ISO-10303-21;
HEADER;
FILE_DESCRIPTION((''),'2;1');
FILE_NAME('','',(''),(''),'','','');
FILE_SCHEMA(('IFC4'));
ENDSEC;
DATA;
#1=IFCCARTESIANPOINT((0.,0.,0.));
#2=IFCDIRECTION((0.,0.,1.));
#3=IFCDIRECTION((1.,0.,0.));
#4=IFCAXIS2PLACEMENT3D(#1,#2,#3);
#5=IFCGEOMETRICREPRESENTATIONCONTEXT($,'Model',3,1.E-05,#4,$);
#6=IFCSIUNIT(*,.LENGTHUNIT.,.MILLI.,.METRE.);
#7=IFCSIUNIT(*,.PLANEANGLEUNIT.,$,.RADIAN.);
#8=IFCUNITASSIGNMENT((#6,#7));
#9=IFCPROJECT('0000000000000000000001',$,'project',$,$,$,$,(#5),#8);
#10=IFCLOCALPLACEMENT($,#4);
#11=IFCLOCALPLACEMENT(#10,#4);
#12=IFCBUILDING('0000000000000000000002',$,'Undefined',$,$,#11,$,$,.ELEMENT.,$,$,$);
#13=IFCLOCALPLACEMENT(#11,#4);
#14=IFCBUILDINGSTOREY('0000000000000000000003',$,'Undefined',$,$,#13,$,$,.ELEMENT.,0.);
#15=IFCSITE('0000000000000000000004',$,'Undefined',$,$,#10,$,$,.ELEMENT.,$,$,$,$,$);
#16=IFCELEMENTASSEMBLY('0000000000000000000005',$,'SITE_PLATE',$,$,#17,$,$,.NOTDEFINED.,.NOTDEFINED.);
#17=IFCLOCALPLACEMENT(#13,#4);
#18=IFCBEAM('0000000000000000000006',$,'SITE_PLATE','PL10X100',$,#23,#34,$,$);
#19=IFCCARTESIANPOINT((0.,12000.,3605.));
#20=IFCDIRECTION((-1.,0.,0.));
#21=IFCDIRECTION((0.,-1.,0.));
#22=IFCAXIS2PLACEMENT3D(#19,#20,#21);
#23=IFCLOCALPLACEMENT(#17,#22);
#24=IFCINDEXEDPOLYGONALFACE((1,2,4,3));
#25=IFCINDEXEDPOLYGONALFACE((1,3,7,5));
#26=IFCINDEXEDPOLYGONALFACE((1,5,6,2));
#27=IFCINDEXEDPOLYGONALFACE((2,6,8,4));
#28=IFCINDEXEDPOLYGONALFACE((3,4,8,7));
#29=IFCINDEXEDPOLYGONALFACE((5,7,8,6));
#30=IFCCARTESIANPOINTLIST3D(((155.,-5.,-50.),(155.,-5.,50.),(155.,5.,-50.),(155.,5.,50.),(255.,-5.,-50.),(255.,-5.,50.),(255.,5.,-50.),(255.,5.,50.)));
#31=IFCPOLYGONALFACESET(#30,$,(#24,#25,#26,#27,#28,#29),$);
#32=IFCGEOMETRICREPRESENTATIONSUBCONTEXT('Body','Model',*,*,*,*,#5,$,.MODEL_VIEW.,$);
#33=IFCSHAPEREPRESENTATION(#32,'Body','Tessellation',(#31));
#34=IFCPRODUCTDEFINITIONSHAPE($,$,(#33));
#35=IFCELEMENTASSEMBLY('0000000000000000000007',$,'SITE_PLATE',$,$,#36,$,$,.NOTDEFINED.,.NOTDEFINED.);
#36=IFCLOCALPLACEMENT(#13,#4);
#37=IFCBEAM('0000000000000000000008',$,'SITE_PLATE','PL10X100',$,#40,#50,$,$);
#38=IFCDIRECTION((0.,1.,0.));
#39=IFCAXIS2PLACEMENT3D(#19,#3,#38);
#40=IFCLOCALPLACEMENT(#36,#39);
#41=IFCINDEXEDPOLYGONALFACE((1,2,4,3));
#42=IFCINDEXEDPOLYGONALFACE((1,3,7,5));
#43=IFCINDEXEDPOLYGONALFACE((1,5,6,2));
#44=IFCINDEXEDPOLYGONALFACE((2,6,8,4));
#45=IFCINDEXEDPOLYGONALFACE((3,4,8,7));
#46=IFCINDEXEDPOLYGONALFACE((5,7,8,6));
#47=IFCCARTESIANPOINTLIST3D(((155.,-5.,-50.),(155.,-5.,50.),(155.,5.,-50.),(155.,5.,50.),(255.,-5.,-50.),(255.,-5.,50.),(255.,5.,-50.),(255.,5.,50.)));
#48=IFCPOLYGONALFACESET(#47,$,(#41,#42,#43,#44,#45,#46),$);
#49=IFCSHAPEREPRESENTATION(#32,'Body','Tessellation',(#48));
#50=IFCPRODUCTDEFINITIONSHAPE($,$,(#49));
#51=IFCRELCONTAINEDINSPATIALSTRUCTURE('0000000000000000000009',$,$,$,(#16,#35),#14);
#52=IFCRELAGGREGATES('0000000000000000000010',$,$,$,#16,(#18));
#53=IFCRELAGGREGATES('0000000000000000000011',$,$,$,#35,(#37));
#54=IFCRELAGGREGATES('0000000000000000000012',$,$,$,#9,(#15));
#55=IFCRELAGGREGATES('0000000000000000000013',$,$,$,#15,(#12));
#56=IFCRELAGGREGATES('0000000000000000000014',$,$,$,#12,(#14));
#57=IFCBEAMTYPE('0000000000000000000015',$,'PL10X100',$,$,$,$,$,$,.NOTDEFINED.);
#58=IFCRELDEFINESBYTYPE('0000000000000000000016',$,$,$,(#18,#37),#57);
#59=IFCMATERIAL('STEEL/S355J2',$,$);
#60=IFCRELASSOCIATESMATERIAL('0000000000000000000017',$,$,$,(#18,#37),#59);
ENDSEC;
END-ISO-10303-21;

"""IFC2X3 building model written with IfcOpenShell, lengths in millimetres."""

from ifc_helpers import new_model, si_unit, frame, origin_with_axes, origin_2d_with_axis, place, context, subcontext, project, spatial, rectangle, extrude, clip, halfspace, material, type_object, element, aggregate, save


model = new_model("IFC2X3")

# Units and contexts
model_context = context("Model", 3, precision=1e-05, world=origin_with_axes())
body_context = subcontext(model_context, "Body", "Model", "MODEL_VIEW")
ifc_project = project(units=[si_unit("LENGTHUNIT", "METRE", prefix="MILLI"), si_unit("PLANEANGLEUNIT", "RADIAN")], contexts=[model_context])

# Site, building, storey
site_placement = place(None, origin_with_axes())
site = spatial("IfcSite", under=ifc_project, at=site_placement, Name="Undefined", CompositionType="ELEMENT")
building_placement = place(site_placement, origin_with_axes())
building = spatial("IfcBuilding", under=site, at=building_placement, Name="Undefined", CompositionType="ELEMENT")
storey_placement = place(building_placement, origin_with_axes())
storey = spatial("IfcBuildingStorey", under=building, at=storey_placement, Name="Undefined", CompositionType="ELEMENT", Elevation=0.0)

# Element assemblies, beams
ifc_material_1 = material(Name="STEEL/S355J2")
assembly_1_placement = place(storey_placement, origin_with_axes())
assembly_1 = element("IfcElementAssembly", 1, at=assembly_1_placement, inside=storey, Name="SITE_PLATE", AssemblyPlace="NOTDEFINED", PredefinedType="NOTDEFINED")
beam_type_1 = type_object("IfcBeamType", Name="PL10X100", PredefinedType="NOTDEFINED")
beam_1_placement = place(assembly_1_placement, frame((0.0, 12000.0, 3605.0), z_axis=(-1.0, 0.0, 0.0), x_axis=(0.0, -1.0, 0.0)))
beam_1 = element("IfcBeam", 2, at=beam_1_placement, type_object=beam_type_1, material=ifc_material_1, Name="SITE_PLATE", Description="PL10X100", context=body_context, shape_type="Clipping", body=[
    clip(extrude(rectangle(XDim=10.0, YDim=100.0, at=origin_2d_with_axis()), frame((255.0, 0.0, 0.0), z_axis=(-1.0, 0.0, 0.0), x_axis=(0.0, -1.0, 0.0)), (0.0, 0.0, 1.0), 255.0), halfspace(frame((155.0, 5.0, -50.0), z_axis=(-1.0, 0.0, 0.0), x_axis=(0.0, 0.0, 1.0)), False)),
])
aggregate(assembly_1, [beam_1])
assembly_2_placement = place(storey_placement, origin_with_axes())
assembly_2 = element("IfcElementAssembly", 3, at=assembly_2_placement, inside=storey, Name="SITE_PLATE", AssemblyPlace="NOTDEFINED", PredefinedType="NOTDEFINED")
beam_2_placement = place(assembly_2_placement, frame((0.0, 12000.0, 3605.0), z_axis=(1.0, 0.0, 0.0), x_axis=(0.0, 1.0, 0.0)))
beam_2 = element("IfcBeam", 4, at=beam_2_placement, type_object=beam_type_1, material=ifc_material_1, Name="SITE_PLATE", Description="PL10X100", context=body_context, shape_type="Clipping", body=[
    clip(extrude(rectangle(XDim=10.0, YDim=100.0, at=origin_2d_with_axis()), frame((255.0, 0.0, 0.0), z_axis=(-1.0, 0.0, 0.0), x_axis=(0.0, -1.0, 0.0)), (0.0, 0.0, 1.0), 255.0), halfspace(frame((155.0, 5.0, -50.0), z_axis=(-1.0, 0.0, 0.0), x_axis=(0.0, 0.0, 1.0)), False)),
])
aggregate(assembly_2, [beam_2])

save(model, "model.ifc")
